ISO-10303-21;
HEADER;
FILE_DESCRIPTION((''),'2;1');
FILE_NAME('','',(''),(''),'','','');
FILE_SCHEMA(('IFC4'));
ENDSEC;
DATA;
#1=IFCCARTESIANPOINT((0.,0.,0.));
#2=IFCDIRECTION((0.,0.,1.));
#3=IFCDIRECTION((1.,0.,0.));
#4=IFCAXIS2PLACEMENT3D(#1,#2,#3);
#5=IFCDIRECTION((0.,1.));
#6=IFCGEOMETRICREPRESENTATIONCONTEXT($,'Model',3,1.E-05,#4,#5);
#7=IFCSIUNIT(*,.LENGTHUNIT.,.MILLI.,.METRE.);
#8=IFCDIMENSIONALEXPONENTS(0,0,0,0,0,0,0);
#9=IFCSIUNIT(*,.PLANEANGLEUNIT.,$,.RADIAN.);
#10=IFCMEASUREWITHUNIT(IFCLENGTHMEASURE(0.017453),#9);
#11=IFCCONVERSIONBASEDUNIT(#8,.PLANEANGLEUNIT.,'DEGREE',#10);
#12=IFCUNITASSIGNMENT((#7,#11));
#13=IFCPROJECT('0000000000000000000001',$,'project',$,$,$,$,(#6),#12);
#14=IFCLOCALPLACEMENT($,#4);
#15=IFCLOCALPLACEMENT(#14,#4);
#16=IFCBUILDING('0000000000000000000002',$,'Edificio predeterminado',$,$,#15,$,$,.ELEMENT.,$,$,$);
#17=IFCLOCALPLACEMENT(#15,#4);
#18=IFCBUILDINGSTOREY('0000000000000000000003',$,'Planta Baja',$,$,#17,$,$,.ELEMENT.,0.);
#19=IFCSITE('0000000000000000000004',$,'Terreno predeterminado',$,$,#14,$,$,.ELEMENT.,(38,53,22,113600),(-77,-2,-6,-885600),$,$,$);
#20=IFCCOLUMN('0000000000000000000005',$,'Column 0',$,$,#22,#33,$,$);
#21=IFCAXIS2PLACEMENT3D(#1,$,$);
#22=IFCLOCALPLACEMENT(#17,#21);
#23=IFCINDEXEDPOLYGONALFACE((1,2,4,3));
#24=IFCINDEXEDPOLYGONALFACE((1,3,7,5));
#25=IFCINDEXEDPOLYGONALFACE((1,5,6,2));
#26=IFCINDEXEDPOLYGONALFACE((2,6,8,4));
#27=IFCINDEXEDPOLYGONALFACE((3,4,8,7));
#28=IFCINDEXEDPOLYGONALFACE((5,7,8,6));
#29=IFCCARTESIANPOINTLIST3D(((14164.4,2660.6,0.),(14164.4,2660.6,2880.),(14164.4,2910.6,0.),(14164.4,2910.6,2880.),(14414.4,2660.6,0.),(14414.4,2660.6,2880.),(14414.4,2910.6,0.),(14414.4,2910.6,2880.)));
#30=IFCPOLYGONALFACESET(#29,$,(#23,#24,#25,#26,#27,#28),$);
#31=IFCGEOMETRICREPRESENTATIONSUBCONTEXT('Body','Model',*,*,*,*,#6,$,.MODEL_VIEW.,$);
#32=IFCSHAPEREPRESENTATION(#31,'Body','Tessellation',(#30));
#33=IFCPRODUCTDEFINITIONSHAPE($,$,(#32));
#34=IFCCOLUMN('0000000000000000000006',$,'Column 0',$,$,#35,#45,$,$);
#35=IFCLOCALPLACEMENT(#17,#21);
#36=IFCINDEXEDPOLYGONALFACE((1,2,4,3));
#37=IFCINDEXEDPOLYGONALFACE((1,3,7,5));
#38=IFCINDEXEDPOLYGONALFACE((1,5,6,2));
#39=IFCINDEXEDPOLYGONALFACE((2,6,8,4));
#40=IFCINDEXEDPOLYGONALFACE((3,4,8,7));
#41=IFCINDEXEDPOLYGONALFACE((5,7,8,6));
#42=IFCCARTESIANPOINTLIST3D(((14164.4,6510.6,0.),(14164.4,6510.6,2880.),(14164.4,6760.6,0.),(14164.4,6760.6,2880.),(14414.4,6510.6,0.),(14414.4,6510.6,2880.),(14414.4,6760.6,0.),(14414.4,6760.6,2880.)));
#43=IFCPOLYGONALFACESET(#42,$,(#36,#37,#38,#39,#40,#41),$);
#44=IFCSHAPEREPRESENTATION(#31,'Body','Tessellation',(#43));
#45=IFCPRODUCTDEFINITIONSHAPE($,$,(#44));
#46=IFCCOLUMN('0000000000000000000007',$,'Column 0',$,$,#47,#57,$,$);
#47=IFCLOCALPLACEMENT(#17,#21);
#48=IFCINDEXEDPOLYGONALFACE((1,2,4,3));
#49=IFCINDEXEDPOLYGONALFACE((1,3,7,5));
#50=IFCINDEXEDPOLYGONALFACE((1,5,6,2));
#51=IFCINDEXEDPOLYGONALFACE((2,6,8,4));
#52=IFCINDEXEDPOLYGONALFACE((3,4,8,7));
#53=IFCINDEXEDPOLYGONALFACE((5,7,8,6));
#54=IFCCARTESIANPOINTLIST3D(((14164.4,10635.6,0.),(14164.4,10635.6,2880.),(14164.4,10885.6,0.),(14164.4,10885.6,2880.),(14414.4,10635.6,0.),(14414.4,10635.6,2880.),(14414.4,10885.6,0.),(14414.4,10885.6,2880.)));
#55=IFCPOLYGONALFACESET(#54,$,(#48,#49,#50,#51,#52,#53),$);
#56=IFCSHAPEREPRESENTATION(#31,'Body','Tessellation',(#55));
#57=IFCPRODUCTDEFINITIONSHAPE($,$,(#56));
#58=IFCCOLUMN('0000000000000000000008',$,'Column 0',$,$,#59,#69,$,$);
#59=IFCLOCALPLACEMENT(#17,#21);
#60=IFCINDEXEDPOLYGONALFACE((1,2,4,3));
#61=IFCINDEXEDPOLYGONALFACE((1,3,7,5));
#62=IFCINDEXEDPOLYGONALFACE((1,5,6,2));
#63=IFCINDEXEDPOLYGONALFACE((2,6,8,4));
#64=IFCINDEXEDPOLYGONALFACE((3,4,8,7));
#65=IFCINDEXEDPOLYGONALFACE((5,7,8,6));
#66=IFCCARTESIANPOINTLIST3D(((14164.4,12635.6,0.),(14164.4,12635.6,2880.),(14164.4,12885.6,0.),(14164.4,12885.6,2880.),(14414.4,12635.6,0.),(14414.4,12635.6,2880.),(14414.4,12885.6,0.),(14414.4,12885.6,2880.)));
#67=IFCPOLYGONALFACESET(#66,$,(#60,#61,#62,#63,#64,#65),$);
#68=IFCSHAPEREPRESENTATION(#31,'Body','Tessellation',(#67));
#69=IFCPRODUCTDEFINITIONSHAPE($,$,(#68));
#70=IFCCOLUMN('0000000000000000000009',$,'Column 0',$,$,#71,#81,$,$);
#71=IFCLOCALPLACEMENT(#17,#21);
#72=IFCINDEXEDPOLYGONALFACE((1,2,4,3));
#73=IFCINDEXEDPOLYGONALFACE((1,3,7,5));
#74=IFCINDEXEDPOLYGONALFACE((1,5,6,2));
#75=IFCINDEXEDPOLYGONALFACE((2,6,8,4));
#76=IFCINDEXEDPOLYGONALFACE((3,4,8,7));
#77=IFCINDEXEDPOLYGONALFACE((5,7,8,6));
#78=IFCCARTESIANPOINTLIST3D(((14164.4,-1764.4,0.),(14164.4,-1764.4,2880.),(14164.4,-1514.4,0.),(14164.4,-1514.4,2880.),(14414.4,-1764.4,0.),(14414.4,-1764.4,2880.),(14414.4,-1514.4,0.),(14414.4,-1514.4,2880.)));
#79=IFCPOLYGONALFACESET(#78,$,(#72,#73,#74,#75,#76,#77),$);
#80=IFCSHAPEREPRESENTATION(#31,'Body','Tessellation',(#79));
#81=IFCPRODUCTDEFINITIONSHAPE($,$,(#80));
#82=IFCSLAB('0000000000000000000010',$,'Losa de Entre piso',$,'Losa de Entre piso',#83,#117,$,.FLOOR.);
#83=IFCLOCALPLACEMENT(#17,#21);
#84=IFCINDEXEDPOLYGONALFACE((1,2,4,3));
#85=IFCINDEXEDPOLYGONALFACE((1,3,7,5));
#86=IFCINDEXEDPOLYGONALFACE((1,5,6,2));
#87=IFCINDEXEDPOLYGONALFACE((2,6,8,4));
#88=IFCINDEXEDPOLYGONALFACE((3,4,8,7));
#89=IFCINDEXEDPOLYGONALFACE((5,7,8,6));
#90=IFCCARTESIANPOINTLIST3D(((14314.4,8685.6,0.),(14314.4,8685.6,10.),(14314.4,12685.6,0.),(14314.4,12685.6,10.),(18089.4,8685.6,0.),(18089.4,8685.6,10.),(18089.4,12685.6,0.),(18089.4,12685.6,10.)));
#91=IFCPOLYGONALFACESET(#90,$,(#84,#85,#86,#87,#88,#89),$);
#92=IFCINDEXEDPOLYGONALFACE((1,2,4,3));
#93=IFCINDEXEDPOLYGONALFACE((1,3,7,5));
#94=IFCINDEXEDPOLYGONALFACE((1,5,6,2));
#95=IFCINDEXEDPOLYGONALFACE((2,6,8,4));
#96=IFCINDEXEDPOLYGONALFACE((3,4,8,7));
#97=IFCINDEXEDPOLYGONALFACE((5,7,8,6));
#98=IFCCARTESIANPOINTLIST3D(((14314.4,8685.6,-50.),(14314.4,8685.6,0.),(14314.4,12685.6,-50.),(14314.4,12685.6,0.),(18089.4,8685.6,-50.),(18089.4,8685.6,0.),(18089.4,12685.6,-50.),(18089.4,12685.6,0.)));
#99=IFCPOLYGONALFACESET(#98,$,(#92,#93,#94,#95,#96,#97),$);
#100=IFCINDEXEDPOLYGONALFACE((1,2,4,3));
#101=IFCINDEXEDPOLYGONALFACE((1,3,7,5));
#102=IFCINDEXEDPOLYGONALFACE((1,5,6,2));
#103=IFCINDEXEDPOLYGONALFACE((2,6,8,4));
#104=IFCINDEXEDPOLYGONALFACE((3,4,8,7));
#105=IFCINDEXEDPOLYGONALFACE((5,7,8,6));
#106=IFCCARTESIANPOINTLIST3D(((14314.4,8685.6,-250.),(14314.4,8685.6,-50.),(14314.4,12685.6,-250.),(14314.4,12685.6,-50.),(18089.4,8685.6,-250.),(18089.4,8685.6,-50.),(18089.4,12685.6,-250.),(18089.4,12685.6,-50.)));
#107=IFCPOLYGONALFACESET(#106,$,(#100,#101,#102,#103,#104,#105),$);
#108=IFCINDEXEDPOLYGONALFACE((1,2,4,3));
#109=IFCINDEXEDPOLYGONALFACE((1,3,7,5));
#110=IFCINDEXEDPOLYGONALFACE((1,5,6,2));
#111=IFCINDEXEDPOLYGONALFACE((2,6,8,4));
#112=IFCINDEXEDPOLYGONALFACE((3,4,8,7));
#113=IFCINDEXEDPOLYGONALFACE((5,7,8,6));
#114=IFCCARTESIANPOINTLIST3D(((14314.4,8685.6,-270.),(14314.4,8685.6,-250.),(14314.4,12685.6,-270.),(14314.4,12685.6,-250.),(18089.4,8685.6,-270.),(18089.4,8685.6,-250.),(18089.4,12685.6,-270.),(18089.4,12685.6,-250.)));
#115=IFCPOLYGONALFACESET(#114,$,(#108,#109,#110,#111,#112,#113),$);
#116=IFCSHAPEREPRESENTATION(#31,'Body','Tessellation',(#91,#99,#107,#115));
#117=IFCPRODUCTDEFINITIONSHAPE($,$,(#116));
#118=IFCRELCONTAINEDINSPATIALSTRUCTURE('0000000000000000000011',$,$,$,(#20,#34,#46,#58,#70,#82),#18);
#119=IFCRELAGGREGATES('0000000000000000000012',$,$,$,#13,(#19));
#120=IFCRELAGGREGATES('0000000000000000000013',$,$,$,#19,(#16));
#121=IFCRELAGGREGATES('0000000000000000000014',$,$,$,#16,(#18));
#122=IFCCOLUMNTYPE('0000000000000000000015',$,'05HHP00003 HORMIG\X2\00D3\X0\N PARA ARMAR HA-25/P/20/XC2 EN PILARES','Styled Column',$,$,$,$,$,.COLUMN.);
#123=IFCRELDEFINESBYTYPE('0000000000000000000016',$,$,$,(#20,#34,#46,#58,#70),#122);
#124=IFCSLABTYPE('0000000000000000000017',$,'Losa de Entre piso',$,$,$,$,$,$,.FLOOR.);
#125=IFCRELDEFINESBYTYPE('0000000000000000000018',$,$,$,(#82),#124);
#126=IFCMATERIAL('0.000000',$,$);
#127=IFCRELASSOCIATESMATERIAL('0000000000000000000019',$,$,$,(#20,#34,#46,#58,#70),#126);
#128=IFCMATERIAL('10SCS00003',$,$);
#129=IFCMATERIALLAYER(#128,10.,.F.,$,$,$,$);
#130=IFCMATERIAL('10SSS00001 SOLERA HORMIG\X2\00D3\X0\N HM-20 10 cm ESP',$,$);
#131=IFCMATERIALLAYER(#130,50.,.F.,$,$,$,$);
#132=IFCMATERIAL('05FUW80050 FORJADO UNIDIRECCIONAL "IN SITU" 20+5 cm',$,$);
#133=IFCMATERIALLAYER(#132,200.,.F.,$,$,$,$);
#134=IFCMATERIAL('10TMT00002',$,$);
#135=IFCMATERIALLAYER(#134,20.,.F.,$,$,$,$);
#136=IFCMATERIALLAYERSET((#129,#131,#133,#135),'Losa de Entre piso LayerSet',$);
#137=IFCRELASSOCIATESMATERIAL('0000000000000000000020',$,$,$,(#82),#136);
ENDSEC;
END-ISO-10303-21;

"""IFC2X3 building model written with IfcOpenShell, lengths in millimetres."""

from ifc_helpers import new_model, entity, si_unit, converted_unit, direction, frame, origin_with_axes, place, context, subcontext, project, spatial, polyline, outline, extrude, material, layer, layer_set, layer_usage, type_object, element, save


model = new_model("IFC2X3")

# Units and contexts
model_context = context("Model", 3, precision=1e-05, world=origin_with_axes(), true_north=direction((0.0, 1.0)))
body_context = subcontext(model_context, "Body", "Model", "MODEL_VIEW")
ifc_project = project(units=[si_unit("LENGTHUNIT", "METRE", prefix="MILLI"), converted_unit("PLANEANGLEUNIT", "DEGREE", entity("IfcLengthMeasure", 0.017453), si_unit("PLANEANGLEUNIT", "RADIAN"), dimensions=[0, 0, 0, 0, 0, 0, 0])], contexts=[model_context])

# Site, building, storey
site_placement = place(None, origin_with_axes())
site = spatial("IfcSite", under=ifc_project, at=site_placement, Name="Terreno predeterminado", CompositionType="ELEMENT", RefLatitude=(38, 53, 22, 113600), RefLongitude=(-77, -2, -6, -885600))
building_placement = place(site_placement, origin_with_axes())
building = spatial("IfcBuilding", under=site, at=building_placement, Name="Edificio predeterminado", CompositionType="ELEMENT")
storey_placement = place(building_placement, origin_with_axes())
storey = spatial("IfcBuildingStorey", under=building, at=storey_placement, Name="Planta Baja", CompositionType="ELEMENT", Elevation=0.0)

# Columns
ifc_material_1 = material(Name="0.000000")
column_type = type_object("IfcColumnType", Name="05HHP00003 HORMIGÓN PARA ARMAR HA-25/P/20/XC2 EN PILARES", Description="Styled Column", PredefinedType="COLUMN")
for number, where, z_axis, x_axis, name in (
    (1, (14289.4, 2785.6, 0.0), (0.0, 0.0, 1.0), (1.0, 0.0, 0.0), "Column 0"),
    (2, (14289.4, 6635.6, 0.0), (0.0, 0.0, 1.0), (1.0, 0.0, 0.0), "Column 0"),
    (3, (14289.4, 10760.6, 0.0), (0.0, 0.0, 1.0), (1.0, 0.0, 0.0), "Column 0"),
    (4, (14289.4, 12760.6, 0.0), (0.0, 0.0, 1.0), (1.0, 0.0, 0.0), "Column 0"),
    (5, (14289.4, -1639.4, 0.0), (0.0, 0.0, 1.0), (1.0, 0.0, 0.0), "Column 0"),
):
    element("IfcColumn", number, at=place(storey_placement, frame(where, z_axis=z_axis, x_axis=x_axis)), inside=storey, type_object=column_type, material=ifc_material_1, Name=name, context=body_context, shape_type="SweptSolid", body=[
        extrude(outline(polyline([(-125.0, -125.0), (125.0, -125.0), (125.0, 125.0), (-125.0, 125.0), (-125.0, -125.0)])), origin_with_axes(), (0.0, 0.0, 1.0), 2880.0),
    ])

# Slab
ifc_material_2 = material(Name="10SCS00003")
ifc_layer_1 = layer(ifc_material_2, 10.0, ventilated=False)
ifc_material_3 = material(Name="10SSS00001 SOLERA HORMIGÓN HM-20 10 cm ESP")
ifc_layer_2 = layer(ifc_material_3, 50.0, ventilated=False)
ifc_material_4 = material(Name="05FUW80050 FORJADO UNIDIRECCIONAL \"IN SITU\" 20+5 cm")
ifc_layer_3 = layer(ifc_material_4, 200.0, ventilated=False)
ifc_material_5 = material(Name="10TMT00002")
ifc_layer_4 = layer(ifc_material_5, 20.0, ventilated=False)
ifc_layer_set_1 = layer_set([ifc_layer_1, ifc_layer_2, ifc_layer_3, ifc_layer_4], Name="Losa de Entre piso LayerSet")
ifc_layer_usage_1 = layer_usage(ifc_layer_set_1, "AXIS3", "NEGATIVE", 0.0)
slab_type = type_object("IfcSlabType", Name="Losa de Entre piso", PredefinedType="FLOOR")
slab_1_placement = place(storey_placement, origin_with_axes())
element("IfcSlab", 6, at=slab_1_placement, inside=storey, type_object=slab_type, material=ifc_layer_usage_1, Name="Losa de Entre piso", ObjectType="Losa de Entre piso", PredefinedType="FLOOR", context=body_context, shape_type="SweptSolid", body=[
    extrude(outline(polyline([(0.0, 4000.0), (3775.0, 4000.0), (3775.0, 0.0), (0.0, 0.0), (0.0, 4000.0)])), frame((14314.4, 12685.6, 0.0), z_axis=(0.0, 0.0, -1.0), x_axis=(1.0, 0.0, 0.0)), (0.0, 0.0, -1.0), 10.0),
    extrude(outline(polyline([(0.0, 4000.0), (3775.0, 4000.0), (3775.0, 0.0), (0.0, 0.0), (0.0, 4000.0)])), frame((14314.4, 12685.6, -50.0), z_axis=(0.0, 0.0, -1.0), x_axis=(1.0, 0.0, 0.0)), (0.0, 0.0, -1.0), 50.0),
    extrude(outline(polyline([(0.0, 4000.0), (3775.0, 4000.0), (3775.0, 0.0), (0.0, 0.0), (0.0, 4000.0)])), frame((14314.4, 12685.6, -250.0), z_axis=(0.0, 0.0, -1.0), x_axis=(1.0, 0.0, 0.0)), (0.0, 0.0, -1.0), 200.0),
    extrude(outline(polyline([(0.0, 4000.0), (3775.0, 4000.0), (3775.0, 0.0), (0.0, 0.0), (0.0, 4000.0)])), frame((14314.4, 12685.6, -270.0), z_axis=(0.0, 0.0, -1.0), x_axis=(1.0, 0.0, 0.0)), (0.0, 0.0, -1.0), 20.0),
])

save(model, "model.ifc")
